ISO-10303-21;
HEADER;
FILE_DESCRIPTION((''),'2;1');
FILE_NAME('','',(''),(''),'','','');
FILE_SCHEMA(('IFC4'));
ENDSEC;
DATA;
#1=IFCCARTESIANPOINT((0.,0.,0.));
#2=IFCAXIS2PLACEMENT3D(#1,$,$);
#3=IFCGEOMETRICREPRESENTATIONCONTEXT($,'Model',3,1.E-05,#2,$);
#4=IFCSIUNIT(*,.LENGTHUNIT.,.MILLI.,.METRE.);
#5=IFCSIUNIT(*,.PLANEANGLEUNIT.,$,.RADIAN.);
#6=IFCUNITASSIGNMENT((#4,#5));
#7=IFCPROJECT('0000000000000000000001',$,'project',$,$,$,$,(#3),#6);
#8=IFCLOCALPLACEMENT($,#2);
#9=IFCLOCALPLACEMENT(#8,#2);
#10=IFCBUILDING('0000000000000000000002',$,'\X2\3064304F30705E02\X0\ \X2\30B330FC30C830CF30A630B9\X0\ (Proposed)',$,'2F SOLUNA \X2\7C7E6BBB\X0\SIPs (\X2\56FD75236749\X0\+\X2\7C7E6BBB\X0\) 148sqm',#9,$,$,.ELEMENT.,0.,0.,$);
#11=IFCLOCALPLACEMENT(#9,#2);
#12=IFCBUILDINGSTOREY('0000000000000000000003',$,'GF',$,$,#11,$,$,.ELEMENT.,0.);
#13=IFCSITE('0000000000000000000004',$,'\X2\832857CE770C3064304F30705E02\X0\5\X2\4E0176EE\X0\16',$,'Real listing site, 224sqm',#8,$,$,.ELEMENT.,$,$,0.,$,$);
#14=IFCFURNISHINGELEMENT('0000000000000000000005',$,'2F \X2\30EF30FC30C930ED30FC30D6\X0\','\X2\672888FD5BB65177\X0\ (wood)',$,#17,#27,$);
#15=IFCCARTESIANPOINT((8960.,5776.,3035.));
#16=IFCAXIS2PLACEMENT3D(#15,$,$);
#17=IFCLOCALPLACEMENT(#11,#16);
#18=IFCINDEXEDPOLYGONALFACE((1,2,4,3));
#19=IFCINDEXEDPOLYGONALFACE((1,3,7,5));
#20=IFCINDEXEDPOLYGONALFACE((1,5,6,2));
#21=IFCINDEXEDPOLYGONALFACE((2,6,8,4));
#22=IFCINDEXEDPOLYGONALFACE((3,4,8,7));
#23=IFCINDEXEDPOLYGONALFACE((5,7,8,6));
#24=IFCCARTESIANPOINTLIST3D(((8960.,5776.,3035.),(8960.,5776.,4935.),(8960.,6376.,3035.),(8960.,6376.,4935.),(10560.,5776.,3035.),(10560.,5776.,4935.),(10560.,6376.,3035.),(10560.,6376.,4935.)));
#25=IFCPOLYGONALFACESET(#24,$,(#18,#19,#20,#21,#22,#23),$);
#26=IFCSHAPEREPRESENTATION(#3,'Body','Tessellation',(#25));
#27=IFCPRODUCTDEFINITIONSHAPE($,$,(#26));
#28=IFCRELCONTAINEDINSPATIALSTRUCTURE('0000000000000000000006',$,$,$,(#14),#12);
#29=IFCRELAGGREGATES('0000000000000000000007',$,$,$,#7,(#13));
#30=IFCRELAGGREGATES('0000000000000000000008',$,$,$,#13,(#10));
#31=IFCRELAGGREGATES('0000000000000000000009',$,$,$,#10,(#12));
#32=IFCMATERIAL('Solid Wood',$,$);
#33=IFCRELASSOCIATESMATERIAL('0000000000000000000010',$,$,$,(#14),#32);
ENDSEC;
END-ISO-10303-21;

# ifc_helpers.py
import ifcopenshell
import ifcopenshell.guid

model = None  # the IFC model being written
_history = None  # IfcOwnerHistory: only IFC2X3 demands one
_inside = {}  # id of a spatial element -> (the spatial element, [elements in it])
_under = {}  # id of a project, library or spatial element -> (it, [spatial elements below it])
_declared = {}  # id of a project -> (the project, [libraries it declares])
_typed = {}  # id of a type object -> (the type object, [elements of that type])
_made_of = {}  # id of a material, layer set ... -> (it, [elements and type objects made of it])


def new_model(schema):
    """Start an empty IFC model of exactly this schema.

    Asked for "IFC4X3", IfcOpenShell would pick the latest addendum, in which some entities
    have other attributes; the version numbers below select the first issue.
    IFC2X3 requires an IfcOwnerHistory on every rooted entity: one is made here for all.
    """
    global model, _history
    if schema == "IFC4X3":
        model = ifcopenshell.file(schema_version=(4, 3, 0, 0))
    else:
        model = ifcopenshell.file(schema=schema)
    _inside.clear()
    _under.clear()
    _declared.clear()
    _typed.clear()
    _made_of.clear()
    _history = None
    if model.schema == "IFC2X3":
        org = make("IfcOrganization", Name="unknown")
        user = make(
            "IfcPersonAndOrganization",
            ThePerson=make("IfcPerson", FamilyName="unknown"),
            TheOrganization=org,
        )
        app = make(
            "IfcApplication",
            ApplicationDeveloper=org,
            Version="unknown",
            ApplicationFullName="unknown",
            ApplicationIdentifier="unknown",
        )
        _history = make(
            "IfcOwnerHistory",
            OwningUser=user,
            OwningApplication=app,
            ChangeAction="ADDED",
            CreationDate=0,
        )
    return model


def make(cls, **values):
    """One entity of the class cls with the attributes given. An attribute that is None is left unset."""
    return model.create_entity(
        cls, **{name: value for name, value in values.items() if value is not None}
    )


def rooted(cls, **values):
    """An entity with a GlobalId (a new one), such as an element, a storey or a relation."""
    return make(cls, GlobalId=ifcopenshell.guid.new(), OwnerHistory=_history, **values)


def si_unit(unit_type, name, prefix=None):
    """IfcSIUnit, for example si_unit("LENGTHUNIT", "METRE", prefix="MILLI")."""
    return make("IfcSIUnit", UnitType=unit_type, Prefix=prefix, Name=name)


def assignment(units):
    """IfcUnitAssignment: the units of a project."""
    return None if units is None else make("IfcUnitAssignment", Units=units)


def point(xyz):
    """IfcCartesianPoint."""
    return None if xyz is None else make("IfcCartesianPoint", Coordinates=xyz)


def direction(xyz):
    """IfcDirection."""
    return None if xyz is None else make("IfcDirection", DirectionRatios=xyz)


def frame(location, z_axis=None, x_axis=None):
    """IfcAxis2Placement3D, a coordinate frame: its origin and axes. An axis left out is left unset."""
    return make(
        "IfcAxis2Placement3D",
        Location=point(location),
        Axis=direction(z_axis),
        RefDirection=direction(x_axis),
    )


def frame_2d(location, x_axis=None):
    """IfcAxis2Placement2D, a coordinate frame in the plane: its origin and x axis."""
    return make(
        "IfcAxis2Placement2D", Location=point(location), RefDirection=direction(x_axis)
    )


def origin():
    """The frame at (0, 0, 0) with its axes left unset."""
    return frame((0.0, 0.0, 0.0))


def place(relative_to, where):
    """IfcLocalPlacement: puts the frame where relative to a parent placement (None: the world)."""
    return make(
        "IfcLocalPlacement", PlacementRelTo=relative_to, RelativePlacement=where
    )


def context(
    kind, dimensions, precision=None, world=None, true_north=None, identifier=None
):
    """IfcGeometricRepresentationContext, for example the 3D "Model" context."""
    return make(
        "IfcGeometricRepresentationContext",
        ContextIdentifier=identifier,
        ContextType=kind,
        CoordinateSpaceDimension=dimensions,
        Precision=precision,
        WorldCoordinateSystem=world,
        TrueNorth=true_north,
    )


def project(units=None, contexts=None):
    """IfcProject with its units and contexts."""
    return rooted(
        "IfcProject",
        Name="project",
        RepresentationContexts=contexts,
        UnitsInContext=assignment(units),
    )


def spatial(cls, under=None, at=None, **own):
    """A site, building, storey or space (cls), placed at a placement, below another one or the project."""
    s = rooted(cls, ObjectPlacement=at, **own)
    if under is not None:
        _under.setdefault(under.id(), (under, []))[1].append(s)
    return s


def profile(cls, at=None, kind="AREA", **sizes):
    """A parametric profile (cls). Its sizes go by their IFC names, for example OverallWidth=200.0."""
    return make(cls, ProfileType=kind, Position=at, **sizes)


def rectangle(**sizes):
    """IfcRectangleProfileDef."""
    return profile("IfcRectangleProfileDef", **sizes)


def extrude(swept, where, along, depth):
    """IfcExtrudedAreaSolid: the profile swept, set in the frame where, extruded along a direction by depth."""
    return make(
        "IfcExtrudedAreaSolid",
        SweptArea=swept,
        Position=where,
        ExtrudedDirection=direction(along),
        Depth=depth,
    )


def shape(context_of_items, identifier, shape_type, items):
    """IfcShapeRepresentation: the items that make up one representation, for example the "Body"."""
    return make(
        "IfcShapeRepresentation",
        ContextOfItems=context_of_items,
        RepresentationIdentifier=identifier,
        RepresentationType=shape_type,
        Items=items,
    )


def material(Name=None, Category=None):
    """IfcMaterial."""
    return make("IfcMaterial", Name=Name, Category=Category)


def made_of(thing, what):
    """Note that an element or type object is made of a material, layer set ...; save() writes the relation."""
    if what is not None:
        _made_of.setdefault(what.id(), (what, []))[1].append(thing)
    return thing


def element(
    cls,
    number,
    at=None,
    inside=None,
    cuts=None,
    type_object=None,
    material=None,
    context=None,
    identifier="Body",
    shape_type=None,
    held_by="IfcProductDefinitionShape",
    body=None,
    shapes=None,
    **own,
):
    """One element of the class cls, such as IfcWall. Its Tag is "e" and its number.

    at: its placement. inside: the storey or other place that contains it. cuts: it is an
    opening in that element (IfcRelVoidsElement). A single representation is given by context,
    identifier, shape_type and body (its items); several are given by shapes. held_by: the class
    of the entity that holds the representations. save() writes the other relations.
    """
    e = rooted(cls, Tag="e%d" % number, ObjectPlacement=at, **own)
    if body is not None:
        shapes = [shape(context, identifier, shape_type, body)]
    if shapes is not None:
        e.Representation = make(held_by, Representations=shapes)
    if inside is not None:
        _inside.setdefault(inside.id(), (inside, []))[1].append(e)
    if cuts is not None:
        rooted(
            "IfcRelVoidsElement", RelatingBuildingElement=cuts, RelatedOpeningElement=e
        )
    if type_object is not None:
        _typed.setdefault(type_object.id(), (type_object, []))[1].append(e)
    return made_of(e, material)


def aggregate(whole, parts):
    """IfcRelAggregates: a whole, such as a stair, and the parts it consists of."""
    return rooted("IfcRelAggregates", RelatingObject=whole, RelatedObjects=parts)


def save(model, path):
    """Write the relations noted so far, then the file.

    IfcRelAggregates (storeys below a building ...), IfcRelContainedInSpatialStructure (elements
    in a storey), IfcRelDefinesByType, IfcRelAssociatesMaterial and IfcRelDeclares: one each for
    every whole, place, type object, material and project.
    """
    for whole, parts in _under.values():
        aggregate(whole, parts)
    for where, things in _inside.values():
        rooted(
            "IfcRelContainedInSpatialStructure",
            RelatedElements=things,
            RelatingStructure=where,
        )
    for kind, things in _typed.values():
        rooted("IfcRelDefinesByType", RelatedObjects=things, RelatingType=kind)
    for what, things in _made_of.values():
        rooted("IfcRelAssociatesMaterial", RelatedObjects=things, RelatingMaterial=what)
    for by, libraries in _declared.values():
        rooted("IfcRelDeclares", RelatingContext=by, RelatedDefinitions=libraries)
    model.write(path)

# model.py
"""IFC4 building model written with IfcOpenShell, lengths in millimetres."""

from ifc_helpers import new_model, si_unit, frame, frame_2d, origin, place, context, project, spatial, rectangle, extrude, material, element, save


model = new_model("IFC4")

# Units and contexts
model_context = context("Model", 3, precision=1e-05, world=origin())
ifc_project = project(units=[si_unit("LENGTHUNIT", "METRE", prefix="MILLI"), si_unit("PLANEANGLEUNIT", "RADIAN")], contexts=[model_context])

# Site, building, storey
site_placement = place(None, origin())
site = spatial("IfcSite", under=ifc_project, at=site_placement, Name="茨城県つくば市5丁目16", ObjectType="Real listing site, 224sqm", CompositionType="ELEMENT", RefElevation=0.0)
building_placement = place(site_placement, origin())
building = spatial("IfcBuilding", under=site, at=building_placement, Name="つくば市 コートハウス (Proposed)", ObjectType="2F SOLUNA 籾殻SIPs (国産杉+籾殻) 148sqm", CompositionType="ELEMENT", ElevationOfRefHeight=0.0, ElevationOfTerrain=0.0)
storey_placement = place(building_placement, origin())
storey = spatial("IfcBuildingStorey", under=building, at=storey_placement, Name="GF", CompositionType="ELEMENT", Elevation=0.0)

# Shared definitions
ifc_material_1 = material(Name="Solid Wood")

# Furnishing element
furnishing_1_placement = place(storey_placement, frame((8960.0, 5776.0, 3035.0)))
element("IfcFurnishingElement", 1, at=furnishing_1_placement, inside=storey, material=ifc_material_1, Name="2F ワードローブ", Description="木製家具 (wood)", context=model_context, shape_type="SweptSolid", body=[
    extrude(rectangle(XDim=1600.0, YDim=600.0, at=frame_2d((800.0, 300.0))), frame((8960.0, 5776.0, 3035.0)), (0.0, 0.0, 1.0), 1900.0),
])

save(model, "model.ifc")
